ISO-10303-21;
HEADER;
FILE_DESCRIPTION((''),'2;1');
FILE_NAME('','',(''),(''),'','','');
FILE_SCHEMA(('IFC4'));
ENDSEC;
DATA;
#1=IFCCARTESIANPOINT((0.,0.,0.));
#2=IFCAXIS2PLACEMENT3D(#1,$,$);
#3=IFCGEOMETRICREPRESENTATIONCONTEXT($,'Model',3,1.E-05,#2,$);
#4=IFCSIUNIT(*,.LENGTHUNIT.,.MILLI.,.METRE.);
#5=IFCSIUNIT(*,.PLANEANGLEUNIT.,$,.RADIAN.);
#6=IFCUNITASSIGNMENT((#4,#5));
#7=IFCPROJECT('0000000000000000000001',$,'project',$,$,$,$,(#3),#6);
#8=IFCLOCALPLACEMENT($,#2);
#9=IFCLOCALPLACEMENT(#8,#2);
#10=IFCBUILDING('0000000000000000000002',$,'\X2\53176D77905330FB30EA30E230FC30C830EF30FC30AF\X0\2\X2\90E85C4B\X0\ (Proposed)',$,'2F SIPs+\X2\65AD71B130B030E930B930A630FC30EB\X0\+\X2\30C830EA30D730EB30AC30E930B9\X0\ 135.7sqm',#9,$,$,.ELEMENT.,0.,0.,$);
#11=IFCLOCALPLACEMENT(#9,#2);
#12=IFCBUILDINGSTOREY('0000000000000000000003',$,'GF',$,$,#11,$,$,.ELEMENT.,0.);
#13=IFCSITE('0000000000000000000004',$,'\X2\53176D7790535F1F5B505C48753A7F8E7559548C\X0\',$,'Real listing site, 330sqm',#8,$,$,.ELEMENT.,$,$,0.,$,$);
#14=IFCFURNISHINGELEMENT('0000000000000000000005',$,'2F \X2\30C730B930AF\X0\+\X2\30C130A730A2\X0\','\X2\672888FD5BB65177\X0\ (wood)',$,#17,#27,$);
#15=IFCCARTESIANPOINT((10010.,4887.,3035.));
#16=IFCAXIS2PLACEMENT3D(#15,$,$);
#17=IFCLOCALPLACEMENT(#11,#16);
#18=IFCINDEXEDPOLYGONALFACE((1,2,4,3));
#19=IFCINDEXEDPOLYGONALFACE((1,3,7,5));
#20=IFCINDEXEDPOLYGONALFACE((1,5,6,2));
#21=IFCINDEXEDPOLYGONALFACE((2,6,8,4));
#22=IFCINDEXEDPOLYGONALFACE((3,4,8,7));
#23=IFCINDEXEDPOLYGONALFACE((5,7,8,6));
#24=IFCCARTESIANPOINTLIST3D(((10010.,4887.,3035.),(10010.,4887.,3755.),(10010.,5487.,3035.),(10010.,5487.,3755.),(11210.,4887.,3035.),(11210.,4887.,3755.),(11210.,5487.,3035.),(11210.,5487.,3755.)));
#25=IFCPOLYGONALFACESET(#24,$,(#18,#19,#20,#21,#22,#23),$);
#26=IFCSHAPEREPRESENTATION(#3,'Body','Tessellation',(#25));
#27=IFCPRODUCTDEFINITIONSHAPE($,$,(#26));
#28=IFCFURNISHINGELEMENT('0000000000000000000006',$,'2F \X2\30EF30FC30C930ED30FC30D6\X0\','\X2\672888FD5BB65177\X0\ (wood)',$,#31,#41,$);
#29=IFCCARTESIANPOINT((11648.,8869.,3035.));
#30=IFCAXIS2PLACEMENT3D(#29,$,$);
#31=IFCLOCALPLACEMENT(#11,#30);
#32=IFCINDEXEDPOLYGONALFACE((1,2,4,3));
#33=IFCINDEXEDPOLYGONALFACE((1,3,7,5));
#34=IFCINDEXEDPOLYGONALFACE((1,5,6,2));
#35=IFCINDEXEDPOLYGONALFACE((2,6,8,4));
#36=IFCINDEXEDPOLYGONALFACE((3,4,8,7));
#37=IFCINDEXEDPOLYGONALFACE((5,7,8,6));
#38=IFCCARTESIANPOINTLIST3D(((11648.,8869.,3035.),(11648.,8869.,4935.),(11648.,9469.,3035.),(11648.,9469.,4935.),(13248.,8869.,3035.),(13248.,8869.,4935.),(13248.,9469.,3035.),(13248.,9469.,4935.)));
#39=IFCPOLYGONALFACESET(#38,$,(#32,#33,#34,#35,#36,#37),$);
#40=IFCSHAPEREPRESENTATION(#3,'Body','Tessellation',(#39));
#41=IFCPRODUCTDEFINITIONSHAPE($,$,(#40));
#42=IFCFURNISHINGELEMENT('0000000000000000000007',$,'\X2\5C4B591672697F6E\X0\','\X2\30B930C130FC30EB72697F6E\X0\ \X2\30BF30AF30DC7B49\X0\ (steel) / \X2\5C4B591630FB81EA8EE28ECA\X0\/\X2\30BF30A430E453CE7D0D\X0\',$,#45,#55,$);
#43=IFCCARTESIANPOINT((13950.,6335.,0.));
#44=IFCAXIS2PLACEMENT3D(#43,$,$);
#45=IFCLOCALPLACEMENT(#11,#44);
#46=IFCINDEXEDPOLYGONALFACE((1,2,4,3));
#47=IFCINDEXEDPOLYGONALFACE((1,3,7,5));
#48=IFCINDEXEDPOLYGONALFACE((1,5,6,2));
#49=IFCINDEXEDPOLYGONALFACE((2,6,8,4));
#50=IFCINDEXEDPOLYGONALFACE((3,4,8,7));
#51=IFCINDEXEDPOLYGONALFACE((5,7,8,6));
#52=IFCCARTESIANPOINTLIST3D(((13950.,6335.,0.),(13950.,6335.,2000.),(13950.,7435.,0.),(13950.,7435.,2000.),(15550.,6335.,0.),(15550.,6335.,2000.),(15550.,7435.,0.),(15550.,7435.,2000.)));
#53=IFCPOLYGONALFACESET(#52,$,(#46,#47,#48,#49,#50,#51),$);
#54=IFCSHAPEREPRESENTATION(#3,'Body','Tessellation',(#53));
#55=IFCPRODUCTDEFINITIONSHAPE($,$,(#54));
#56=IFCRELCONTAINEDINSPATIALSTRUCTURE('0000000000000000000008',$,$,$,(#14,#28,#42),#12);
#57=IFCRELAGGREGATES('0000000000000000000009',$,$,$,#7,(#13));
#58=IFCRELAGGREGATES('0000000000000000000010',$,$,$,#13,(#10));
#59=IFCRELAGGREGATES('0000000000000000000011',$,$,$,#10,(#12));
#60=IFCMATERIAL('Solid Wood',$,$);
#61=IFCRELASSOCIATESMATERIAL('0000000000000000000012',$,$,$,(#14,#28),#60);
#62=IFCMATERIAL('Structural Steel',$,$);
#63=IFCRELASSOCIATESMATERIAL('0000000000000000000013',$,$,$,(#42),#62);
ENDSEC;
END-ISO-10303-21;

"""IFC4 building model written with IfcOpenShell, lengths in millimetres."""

from ifc_helpers import new_model, si_unit, frame, frame_2d, origin, place, context, project, spatial, rectangle, extrude, material, element, save


model = new_model("IFC4")

# Units and contexts
model_context = context("Model", 3, precision=1e-05, world=origin())
ifc_project = project(units=[si_unit("LENGTHUNIT", "METRE", prefix="MILLI"), si_unit("PLANEANGLEUNIT", "RADIAN")], contexts=[model_context])

# Site, building, storey
site_placement = place(None, origin())
site = spatial("IfcSite", under=ifc_project, at=site_placement, Name="北海道弟子屈町美留和", ObjectType="Real listing site, 330sqm", CompositionType="ELEMENT", RefElevation=0.0)
building_placement = place(site_placement, origin())
building = spatial("IfcBuilding", under=site, at=building_placement, Name="北海道・リモートワーク2部屋 (Proposed)", ObjectType="2F SIPs+断熱グラスウール+トリプルガラス 135.7sqm", CompositionType="ELEMENT", ElevationOfRefHeight=0.0, ElevationOfTerrain=0.0)
storey_placement = place(building_placement, origin())
storey = spatial("IfcBuildingStorey", under=building, at=storey_placement, Name="GF", CompositionType="ELEMENT", Elevation=0.0)

# Shared definitions
ifc_material_1 = material(Name="Solid Wood")

# Shared definitions
ifc_material_2 = material(Name="Structural Steel")

# Furnishing elements
furnishing_1_placement = place(storey_placement, frame((10010.0, 4887.0, 3035.0)))
element("IfcFurnishingElement", 1, at=furnishing_1_placement, inside=storey, material=ifc_material_1, Name="2F デスク+チェア", Description="木製家具 (wood)", context=model_context, shape_type="SweptSolid", body=[
    extrude(rectangle(XDim=1200.0, YDim=600.0, at=frame_2d((600.0, 300.0))), frame((10010.0, 4887.0, 3035.0)), (0.0, 0.0, 1.0), 720.0),
])
furnishing_2_placement = place(storey_placement, frame((11648.0, 8869.0, 3035.0)))
element("IfcFurnishingElement", 2, at=furnishing_2_placement, inside=storey, material=ifc_material_1, Name="2F ワードローブ", Description="木製家具 (wood)", context=model_context, shape_type="SweptSolid", body=[
    extrude(rectangle(XDim=1600.0, YDim=600.0, at=frame_2d((800.0, 300.0))), frame((11648.0, 8869.0, 3035.0)), (0.0, 0.0, 1.0), 1900.0),
])
furnishing_3_placement = place(storey_placement, frame((13950.0, 6335.0, 0.0)))
element("IfcFurnishingElement", 3, at=furnishing_3_placement, inside=storey, material=ifc_material_2, Name="屋外物置", Description="スチール物置 タクボ等 (steel) / 屋外・自転車/タイヤ収納", context=model_context, shape_type="SweptSolid", body=[
    extrude(rectangle(XDim=1600.0, YDim=1100.0, at=frame_2d((800.0, 550.0))), frame((13950.0, 6335.0, 0.0)), (0.0, 0.0, 1.0), 2000.0),
])

save(model, "model.ifc")
